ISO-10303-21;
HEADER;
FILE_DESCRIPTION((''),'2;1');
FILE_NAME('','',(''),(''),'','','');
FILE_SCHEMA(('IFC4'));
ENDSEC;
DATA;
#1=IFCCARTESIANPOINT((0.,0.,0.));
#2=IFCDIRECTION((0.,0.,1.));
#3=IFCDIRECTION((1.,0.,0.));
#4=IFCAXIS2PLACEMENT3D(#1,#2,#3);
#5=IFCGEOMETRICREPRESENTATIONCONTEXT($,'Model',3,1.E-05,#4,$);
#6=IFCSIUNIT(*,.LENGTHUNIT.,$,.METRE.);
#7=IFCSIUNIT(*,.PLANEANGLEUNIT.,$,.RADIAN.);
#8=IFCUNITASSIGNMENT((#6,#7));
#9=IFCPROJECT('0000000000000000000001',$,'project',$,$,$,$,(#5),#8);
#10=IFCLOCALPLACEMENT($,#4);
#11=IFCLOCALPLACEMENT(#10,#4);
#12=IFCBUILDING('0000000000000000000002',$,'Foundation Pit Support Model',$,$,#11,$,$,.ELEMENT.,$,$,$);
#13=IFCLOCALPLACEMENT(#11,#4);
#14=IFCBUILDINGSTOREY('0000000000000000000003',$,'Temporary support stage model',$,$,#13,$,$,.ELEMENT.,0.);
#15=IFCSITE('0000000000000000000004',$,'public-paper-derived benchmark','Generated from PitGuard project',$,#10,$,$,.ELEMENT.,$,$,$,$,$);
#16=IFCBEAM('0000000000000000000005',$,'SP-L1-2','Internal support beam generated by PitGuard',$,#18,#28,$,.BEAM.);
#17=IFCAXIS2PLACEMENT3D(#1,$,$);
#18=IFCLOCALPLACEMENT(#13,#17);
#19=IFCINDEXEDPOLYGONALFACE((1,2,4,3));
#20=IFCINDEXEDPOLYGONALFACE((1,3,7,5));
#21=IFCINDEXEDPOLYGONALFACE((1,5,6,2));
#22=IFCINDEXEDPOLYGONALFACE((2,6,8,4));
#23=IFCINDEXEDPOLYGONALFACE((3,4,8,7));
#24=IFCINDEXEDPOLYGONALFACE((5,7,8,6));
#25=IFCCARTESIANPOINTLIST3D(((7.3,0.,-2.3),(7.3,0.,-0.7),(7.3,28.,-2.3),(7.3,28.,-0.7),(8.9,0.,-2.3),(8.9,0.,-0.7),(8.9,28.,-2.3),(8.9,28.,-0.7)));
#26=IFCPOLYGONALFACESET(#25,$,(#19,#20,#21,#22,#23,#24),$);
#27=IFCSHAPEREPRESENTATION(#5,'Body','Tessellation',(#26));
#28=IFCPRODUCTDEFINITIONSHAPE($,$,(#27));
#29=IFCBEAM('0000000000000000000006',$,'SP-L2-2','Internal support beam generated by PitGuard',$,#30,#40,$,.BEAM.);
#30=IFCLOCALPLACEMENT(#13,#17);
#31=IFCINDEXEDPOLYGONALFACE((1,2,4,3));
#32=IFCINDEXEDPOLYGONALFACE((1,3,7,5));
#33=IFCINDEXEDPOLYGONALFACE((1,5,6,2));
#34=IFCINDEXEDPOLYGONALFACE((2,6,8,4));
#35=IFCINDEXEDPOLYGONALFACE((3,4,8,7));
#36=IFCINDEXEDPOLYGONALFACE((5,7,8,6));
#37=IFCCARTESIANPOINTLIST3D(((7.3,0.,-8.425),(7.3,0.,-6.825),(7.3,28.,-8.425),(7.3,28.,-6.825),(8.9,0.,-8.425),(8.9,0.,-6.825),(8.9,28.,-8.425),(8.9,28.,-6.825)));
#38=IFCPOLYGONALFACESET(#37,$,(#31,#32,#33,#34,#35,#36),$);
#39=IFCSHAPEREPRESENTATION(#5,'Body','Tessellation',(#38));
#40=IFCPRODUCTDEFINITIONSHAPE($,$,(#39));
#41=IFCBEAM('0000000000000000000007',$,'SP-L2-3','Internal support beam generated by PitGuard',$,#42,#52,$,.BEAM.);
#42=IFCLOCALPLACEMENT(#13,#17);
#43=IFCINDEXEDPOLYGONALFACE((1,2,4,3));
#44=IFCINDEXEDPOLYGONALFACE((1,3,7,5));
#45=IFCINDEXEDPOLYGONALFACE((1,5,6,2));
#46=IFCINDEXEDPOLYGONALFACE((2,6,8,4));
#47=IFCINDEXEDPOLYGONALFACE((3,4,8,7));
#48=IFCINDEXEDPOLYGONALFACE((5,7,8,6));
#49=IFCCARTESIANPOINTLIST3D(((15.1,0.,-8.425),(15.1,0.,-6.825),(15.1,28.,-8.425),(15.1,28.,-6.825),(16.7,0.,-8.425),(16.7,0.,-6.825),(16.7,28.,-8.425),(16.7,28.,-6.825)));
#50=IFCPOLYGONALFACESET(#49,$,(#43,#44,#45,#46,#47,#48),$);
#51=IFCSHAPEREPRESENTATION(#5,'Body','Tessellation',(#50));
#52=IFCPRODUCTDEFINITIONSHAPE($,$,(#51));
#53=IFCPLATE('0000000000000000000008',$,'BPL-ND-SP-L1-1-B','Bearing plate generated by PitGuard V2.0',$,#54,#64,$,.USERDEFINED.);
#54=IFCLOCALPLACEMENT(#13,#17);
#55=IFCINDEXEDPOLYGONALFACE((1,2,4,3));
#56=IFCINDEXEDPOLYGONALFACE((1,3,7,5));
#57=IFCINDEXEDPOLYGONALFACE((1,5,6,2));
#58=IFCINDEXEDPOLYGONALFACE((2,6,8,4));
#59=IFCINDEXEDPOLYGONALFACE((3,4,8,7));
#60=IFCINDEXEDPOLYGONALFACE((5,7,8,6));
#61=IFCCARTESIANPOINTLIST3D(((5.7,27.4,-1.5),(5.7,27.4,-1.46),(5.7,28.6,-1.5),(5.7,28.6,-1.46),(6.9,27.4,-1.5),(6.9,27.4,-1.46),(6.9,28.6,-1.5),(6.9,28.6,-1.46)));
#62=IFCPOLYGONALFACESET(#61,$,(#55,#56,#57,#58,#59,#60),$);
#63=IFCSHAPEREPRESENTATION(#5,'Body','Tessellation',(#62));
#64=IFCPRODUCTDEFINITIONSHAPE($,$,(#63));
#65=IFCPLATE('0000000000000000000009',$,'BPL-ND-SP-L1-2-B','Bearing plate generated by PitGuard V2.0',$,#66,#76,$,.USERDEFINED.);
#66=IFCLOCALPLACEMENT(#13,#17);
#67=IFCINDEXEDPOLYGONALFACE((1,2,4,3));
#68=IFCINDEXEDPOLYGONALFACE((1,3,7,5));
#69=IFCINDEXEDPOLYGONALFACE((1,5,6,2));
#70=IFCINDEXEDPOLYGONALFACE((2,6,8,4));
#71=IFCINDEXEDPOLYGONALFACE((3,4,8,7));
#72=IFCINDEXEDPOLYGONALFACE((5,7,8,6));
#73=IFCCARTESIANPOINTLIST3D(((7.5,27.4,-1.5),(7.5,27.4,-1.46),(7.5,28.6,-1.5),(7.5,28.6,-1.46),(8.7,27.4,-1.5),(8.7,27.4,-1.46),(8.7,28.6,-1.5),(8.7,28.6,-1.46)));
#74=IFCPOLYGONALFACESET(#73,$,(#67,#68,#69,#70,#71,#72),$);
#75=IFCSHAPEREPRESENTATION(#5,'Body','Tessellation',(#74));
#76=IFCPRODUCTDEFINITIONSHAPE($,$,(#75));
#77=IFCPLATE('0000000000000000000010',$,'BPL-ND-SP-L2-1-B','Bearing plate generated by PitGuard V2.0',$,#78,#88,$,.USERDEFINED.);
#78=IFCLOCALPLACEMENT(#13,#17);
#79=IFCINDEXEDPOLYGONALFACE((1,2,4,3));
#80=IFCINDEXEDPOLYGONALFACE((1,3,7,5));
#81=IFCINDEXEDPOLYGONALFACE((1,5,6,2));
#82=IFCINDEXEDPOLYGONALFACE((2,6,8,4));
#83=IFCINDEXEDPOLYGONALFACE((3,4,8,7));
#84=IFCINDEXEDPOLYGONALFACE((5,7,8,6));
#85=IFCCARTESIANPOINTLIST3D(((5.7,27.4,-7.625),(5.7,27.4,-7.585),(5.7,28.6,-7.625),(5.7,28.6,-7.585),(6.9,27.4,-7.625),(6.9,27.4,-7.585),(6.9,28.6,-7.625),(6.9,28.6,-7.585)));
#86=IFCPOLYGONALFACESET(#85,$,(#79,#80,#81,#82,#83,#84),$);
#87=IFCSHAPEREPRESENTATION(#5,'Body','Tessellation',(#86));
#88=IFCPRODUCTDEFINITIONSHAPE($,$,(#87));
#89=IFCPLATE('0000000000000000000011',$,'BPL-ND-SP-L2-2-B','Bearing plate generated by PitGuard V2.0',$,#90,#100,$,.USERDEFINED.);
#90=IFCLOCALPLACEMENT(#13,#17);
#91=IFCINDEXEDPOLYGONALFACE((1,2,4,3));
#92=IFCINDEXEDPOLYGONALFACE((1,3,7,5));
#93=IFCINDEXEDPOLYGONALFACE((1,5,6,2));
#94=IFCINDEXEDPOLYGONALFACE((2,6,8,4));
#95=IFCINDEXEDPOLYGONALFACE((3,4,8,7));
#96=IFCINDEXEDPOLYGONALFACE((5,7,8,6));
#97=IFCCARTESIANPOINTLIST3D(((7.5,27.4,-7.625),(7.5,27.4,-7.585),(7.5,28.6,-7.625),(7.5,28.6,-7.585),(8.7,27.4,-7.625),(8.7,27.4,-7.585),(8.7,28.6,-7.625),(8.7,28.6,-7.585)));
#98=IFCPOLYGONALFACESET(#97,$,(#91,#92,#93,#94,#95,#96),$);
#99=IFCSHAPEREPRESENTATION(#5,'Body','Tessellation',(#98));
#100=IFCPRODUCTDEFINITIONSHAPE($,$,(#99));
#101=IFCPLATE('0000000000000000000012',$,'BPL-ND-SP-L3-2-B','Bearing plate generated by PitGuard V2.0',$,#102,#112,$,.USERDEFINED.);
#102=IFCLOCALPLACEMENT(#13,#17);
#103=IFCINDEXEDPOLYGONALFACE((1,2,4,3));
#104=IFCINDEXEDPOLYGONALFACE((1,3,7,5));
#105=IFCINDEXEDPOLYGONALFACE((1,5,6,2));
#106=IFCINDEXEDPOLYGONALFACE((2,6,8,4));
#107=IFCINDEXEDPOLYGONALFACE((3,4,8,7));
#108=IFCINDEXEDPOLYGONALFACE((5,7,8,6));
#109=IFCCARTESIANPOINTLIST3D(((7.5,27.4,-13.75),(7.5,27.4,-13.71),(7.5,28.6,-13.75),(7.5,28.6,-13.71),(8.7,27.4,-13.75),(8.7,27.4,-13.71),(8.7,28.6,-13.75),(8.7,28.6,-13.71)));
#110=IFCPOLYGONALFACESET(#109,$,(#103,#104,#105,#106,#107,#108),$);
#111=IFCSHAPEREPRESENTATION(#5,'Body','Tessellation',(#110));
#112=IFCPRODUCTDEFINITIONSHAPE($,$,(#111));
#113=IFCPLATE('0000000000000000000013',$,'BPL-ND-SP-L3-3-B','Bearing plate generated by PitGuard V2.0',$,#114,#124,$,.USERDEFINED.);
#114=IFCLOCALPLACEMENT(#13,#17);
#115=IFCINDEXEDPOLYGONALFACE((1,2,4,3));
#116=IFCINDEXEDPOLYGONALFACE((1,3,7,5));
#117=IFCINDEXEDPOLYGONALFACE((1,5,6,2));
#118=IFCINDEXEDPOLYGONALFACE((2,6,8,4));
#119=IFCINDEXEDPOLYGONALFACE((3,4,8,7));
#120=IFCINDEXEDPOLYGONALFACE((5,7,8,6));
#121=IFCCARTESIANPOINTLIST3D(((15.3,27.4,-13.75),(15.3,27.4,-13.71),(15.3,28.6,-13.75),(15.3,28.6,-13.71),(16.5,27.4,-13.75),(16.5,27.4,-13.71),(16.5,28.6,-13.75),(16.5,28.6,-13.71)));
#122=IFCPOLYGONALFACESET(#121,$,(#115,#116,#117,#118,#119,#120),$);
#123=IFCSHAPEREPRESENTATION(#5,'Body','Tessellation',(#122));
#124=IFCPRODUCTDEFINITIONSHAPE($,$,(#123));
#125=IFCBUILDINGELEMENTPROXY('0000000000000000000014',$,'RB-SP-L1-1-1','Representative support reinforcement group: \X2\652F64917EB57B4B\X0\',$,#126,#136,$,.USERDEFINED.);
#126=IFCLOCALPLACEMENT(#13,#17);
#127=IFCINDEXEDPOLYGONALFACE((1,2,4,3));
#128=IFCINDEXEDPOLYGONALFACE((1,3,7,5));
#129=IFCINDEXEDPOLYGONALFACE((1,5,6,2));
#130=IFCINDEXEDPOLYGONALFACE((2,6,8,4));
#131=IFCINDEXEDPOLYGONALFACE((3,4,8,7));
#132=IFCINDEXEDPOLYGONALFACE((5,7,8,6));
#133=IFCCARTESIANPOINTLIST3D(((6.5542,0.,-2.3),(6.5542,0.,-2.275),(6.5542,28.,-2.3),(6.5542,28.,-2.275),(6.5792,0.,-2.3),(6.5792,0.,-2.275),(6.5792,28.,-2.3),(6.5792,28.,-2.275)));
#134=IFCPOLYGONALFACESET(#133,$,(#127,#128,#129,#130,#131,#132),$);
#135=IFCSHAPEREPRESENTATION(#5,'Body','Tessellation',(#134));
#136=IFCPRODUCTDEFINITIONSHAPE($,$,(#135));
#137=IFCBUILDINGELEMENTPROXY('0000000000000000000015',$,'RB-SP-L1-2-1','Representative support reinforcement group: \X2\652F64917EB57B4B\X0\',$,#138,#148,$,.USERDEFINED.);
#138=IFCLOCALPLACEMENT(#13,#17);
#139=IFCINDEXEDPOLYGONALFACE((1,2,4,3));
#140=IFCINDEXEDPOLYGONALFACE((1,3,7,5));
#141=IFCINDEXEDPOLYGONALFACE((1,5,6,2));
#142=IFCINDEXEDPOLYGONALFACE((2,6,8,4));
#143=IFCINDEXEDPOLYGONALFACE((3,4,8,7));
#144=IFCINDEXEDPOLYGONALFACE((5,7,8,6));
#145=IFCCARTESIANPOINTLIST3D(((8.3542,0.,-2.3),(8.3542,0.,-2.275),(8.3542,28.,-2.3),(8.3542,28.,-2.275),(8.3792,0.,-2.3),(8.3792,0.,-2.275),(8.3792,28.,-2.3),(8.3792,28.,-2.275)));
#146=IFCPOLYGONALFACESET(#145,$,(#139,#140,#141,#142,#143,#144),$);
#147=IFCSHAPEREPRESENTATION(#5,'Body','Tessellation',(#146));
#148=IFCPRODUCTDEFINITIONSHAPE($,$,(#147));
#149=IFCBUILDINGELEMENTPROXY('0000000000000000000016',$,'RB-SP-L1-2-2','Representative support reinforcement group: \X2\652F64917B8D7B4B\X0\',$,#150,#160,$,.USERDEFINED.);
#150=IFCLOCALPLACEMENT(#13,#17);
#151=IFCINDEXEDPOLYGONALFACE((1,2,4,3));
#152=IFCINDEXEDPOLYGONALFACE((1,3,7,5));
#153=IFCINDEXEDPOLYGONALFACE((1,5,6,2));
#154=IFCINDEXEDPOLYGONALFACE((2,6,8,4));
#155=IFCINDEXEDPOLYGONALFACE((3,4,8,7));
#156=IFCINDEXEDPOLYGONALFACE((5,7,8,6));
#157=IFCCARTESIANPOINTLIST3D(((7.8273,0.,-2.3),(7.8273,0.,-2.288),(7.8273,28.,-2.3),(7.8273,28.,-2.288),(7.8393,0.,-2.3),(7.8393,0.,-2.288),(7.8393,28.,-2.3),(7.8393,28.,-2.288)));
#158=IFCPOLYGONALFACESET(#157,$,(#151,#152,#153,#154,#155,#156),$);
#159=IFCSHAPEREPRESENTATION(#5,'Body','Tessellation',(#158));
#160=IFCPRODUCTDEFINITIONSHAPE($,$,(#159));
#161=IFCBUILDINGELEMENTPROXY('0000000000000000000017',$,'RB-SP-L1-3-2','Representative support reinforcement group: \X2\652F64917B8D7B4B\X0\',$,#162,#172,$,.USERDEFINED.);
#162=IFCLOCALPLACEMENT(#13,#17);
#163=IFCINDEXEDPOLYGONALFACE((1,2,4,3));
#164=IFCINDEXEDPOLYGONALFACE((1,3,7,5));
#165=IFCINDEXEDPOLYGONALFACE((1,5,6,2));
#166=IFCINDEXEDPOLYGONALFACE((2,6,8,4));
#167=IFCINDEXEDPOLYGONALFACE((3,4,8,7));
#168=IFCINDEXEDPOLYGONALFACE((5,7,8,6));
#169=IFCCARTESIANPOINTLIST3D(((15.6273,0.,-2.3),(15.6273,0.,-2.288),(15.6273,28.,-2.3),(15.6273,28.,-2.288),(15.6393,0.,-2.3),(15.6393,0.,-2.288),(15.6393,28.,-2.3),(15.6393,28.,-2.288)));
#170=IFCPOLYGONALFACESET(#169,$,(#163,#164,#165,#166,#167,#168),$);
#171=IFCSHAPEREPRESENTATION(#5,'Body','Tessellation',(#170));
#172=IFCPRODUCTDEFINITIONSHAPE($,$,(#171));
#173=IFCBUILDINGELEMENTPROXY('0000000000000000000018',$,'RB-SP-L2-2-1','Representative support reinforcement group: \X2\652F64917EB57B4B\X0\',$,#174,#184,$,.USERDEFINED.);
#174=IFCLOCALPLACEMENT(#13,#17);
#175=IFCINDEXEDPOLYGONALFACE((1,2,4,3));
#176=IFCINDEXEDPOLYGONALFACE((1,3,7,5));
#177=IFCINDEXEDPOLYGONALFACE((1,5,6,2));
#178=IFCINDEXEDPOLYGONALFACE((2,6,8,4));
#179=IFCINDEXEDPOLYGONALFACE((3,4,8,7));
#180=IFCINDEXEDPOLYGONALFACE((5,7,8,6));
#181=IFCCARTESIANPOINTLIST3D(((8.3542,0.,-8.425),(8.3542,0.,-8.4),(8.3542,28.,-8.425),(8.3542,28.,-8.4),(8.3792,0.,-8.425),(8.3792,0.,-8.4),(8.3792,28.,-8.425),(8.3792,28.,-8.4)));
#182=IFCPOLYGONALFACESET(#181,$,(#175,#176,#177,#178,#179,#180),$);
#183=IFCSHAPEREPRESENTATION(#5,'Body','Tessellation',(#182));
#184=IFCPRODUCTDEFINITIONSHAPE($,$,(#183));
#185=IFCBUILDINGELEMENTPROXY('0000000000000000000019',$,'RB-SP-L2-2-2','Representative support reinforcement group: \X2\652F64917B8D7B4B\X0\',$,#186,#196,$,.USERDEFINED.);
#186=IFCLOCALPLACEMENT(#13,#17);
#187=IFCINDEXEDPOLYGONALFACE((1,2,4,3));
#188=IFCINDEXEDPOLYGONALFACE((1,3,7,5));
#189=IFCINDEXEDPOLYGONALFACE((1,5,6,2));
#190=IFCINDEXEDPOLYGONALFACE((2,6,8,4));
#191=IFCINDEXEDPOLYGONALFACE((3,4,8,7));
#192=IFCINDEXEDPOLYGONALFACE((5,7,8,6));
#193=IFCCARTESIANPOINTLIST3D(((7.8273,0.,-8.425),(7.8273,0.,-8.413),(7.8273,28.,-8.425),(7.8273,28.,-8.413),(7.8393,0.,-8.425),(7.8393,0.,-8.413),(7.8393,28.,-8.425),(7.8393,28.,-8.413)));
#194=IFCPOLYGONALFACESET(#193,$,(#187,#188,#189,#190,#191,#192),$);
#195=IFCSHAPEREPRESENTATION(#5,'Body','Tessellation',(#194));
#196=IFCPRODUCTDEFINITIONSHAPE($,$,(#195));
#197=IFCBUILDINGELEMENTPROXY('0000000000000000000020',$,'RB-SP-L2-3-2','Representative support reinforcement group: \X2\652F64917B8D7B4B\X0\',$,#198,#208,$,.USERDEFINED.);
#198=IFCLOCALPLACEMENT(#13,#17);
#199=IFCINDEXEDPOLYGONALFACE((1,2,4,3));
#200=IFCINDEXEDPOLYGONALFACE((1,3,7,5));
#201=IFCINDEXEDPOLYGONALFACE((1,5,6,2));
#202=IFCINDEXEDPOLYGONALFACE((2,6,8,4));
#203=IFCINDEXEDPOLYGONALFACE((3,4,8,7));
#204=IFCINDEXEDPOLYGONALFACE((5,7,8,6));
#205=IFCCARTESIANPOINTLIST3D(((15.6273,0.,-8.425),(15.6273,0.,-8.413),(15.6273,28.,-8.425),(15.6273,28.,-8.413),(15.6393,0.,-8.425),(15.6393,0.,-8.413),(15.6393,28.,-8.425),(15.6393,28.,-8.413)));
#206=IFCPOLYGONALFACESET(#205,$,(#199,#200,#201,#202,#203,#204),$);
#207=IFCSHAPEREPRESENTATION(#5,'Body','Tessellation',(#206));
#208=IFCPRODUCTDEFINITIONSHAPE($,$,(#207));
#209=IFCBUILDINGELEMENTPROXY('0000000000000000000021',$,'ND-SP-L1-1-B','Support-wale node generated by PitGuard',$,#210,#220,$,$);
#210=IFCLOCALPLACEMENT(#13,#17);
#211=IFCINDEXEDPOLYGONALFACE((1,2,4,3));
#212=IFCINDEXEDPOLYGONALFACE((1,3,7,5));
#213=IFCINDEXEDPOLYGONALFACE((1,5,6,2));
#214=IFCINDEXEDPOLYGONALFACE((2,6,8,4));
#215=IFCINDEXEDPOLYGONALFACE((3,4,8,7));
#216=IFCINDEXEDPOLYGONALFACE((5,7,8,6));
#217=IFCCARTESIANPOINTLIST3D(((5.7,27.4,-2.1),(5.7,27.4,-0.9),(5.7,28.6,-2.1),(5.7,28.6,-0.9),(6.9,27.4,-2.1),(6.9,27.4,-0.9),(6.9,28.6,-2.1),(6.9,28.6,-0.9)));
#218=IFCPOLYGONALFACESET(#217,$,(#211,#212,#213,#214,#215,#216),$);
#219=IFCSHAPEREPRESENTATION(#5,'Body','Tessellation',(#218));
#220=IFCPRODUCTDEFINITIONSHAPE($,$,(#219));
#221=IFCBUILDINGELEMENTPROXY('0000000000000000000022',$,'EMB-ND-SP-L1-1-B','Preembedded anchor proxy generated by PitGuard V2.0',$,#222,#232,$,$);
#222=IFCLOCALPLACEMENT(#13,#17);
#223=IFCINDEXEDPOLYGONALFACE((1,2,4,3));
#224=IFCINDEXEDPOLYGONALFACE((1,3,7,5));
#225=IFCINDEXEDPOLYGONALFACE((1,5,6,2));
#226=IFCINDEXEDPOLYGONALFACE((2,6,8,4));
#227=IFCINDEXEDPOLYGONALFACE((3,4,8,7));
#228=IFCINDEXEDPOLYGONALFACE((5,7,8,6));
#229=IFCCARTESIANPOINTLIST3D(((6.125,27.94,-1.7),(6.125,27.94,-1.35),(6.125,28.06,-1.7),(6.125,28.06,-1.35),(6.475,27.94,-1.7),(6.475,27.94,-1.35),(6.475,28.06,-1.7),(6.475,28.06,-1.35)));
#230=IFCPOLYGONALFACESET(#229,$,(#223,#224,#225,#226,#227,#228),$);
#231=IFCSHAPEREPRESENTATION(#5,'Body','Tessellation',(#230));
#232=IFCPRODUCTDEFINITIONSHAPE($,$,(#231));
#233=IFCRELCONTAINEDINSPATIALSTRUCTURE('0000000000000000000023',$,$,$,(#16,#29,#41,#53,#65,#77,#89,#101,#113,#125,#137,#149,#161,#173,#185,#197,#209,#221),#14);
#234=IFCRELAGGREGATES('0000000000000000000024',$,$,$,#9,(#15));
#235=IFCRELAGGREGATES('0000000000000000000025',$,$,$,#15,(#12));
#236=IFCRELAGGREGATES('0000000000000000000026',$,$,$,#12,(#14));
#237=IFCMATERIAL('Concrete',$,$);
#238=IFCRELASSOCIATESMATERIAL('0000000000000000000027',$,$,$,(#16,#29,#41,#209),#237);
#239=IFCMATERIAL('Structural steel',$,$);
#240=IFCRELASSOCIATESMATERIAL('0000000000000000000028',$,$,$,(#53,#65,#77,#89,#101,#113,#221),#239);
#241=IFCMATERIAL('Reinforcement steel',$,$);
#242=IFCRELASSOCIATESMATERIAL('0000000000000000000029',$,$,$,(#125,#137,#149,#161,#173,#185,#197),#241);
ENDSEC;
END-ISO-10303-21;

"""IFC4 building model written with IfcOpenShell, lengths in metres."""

from ifc_helpers import new_model, si_unit, frame, origin_with_axes, origin_2d, place, context, project, spatial, rectangle, extrude, material, element, save


model = new_model("IFC4")

# Units and contexts
model_context = context("Model", 3, precision=1e-05, world=origin_with_axes())
ifc_project = project(units=[si_unit("LENGTHUNIT", "METRE"), si_unit("PLANEANGLEUNIT", "RADIAN")], contexts=[model_context])

# Site, building, storey
site_placement = place(None, origin_with_axes())
site = spatial("IfcSite", under=ifc_project, at=site_placement, Name="public-paper-derived benchmark", Description="Generated from PitGuard project", CompositionType="ELEMENT")
building_placement = place(site_placement, origin_with_axes())
building = spatial("IfcBuilding", under=site, at=building_placement, Name="Foundation Pit Support Model", CompositionType="ELEMENT")
storey_placement = place(building_placement, origin_with_axes())
storey = spatial("IfcBuildingStorey", under=building, at=storey_placement, Name="Temporary support stage model", CompositionType="ELEMENT", Elevation=0.0)

# Beams
ifc_material_1 = material(Name="Concrete")
for number, where, z_axis, x_axis, name in (
    (1, (8.1, 14.0, -2.3), (0.0, 0.0, 1.0), (0.0, 1.0, 0.0), "SP-L1-2"),
    (2, (8.1, 14.0, -8.425), (0.0, 0.0, 1.0), (0.0, 1.0, 0.0), "SP-L2-2"),
    (3, (15.9, 14.0, -8.425), (0.0, 0.0, 1.0), (0.0, 1.0, 0.0), "SP-L2-3"),
):
    element("IfcBeam", number, at=place(storey_placement, frame(where, z_axis=z_axis, x_axis=x_axis)), inside=storey, material=ifc_material_1, Name=name, Description="Internal support beam generated by PitGuard", PredefinedType="BEAM", context=model_context, shape_type="SweptSolid", body=[
        extrude(rectangle(XDim=28.0, YDim=1.6, at=origin_2d()), origin_with_axes(), (0.0, 0.0, 1.0), 1.6),
    ])

# Plates
ifc_material_2 = material(Name="Structural steel")
for number, where, z_axis, x_axis, name in (
    (4, (6.3, 28.0, -1.5), (0.0, 0.0, 1.0), (1.0, 0.0, 0.0), "BPL-ND-SP-L1-1-B"),
    (5, (8.1, 28.0, -1.5), (0.0, 0.0, 1.0), (1.0, 0.0, 0.0), "BPL-ND-SP-L1-2-B"),
    (6, (6.3, 28.0, -7.625), (0.0, 0.0, 1.0), (1.0, 0.0, 0.0), "BPL-ND-SP-L2-1-B"),
    (7, (8.1, 28.0, -7.625), (0.0, 0.0, 1.0), (1.0, 0.0, 0.0), "BPL-ND-SP-L2-2-B"),
    (8, (8.1, 28.0, -13.75), (0.0, 0.0, 1.0), (1.0, 0.0, 0.0), "BPL-ND-SP-L3-2-B"),
    (9, (15.9, 28.0, -13.75), (0.0, 0.0, 1.0), (1.0, 0.0, 0.0), "BPL-ND-SP-L3-3-B"),
):
    element("IfcPlate", number, at=place(storey_placement, frame(where, z_axis=z_axis, x_axis=x_axis)), inside=storey, material=ifc_material_2, Name=name, Description="Bearing plate generated by PitGuard V2.0", PredefinedType="USERDEFINED", context=model_context, shape_type="SweptSolid", body=[
        extrude(rectangle(XDim=1.2, YDim=1.2, at=origin_2d()), origin_with_axes(), (0.0, 0.0, 1.0), 0.04),
    ])

# Building element proxies
ifc_material_3 = material(Name="Reinforcement steel")
for number, where, z_axis, x_axis, name in (
    (10, (6.5667, 14.0, -2.3), (0.0, 0.0, 1.0), (0.0, 1.0, 0.0), "RB-SP-L1-1-1"),
    (11, (8.3667, 14.0, -2.3), (0.0, 0.0, 1.0), (0.0, 1.0, 0.0), "RB-SP-L1-2-1"),
):
    element("IfcBuildingElementProxy", number, at=place(storey_placement, frame(where, z_axis=z_axis, x_axis=x_axis)), inside=storey, material=ifc_material_3, Name=name, Description="Representative support reinforcement group: 支撑纵筋", PredefinedType="USERDEFINED", context=model_context, shape_type="SweptSolid", body=[
        extrude(rectangle(XDim=28.0, YDim=0.025, at=origin_2d()), origin_with_axes(), (0.0, 0.0, 1.0), 0.025),
    ])
for number, where, z_axis, x_axis, name in (
    (12, (7.8333, 14.0, -2.3), (0.0, 0.0, 1.0), (0.0, 1.0, 0.0), "RB-SP-L1-2-2"),
    (13, (15.6333, 14.0, -2.3), (0.0, 0.0, 1.0), (0.0, 1.0, 0.0), "RB-SP-L1-3-2"),
):
    element("IfcBuildingElementProxy", number, at=place(storey_placement, frame(where, z_axis=z_axis, x_axis=x_axis)), inside=storey, material=ifc_material_3, Name=name, Description="Representative support reinforcement group: 支撑箍筋", PredefinedType="USERDEFINED", context=model_context, shape_type="SweptSolid", body=[
        extrude(rectangle(XDim=28.0, YDim=0.012, at=origin_2d()), origin_with_axes(), (0.0, 0.0, 1.0), 0.012),
    ])
proxy_1_placement = place(storey_placement, frame((8.3667, 14.0, -8.425), z_axis=(0.0, 0.0, 1.0), x_axis=(0.0, 1.0, 0.0)))
element("IfcBuildingElementProxy", 14, at=proxy_1_placement, inside=storey, material=ifc_material_3, Name="RB-SP-L2-2-1", Description="Representative support reinforcement group: 支撑纵筋", PredefinedType="USERDEFINED", context=model_context, shape_type="SweptSolid", body=[
    extrude(rectangle(XDim=28.0, YDim=0.025, at=origin_2d()), origin_with_axes(), (0.0, 0.0, 1.0), 0.025),
])
for number, where, z_axis, x_axis, name in (
    (15, (7.8333, 14.0, -8.425), (0.0, 0.0, 1.0), (0.0, 1.0, 0.0), "RB-SP-L2-2-2"),
    (16, (15.6333, 14.0, -8.425), (0.0, 0.0, 1.0), (0.0, 1.0, 0.0), "RB-SP-L2-3-2"),
):
    element("IfcBuildingElementProxy", number, at=place(storey_placement, frame(where, z_axis=z_axis, x_axis=x_axis)), inside=storey, material=ifc_material_3, Name=name, Description="Representative support reinforcement group: 支撑箍筋", PredefinedType="USERDEFINED", context=model_context, shape_type="SweptSolid", body=[
        extrude(rectangle(XDim=28.0, YDim=0.012, at=origin_2d()), origin_with_axes(), (0.0, 0.0, 1.0), 0.012),
    ])
proxy_2_placement = place(storey_placement, frame((6.3, 28.0, -2.1), z_axis=(0.0, 0.0, 1.0), x_axis=(1.0, 0.0, 0.0)))
element("IfcBuildingElementProxy", 17, at=proxy_2_placement, inside=storey, material=ifc_material_1, Name="ND-SP-L1-1-B", Description="Support-wale node generated by PitGuard", context=model_context, shape_type="SweptSolid", body=[
    extrude(rectangle(XDim=1.2, YDim=1.2, at=origin_2d()), origin_with_axes(), (0.0, 0.0, 1.0), 1.2),
])
proxy_3_placement = place(storey_placement, frame((6.3, 28.0, -1.7), z_axis=(0.0, 0.0, 1.0), x_axis=(1.0, 0.0, 0.0)))
element("IfcBuildingElementProxy", 18, at=proxy_3_placement, inside=storey, material=ifc_material_2, Name="EMB-ND-SP-L1-1-B", Description="Preembedded anchor proxy generated by PitGuard V2.0", context=model_context, shape_type="SweptSolid", body=[
    extrude(rectangle(XDim=0.35, YDim=0.12, at=origin_2d()), origin_with_axes(), (0.0, 0.0, 1.0), 0.35),
])

save(model, "model.ifc")
